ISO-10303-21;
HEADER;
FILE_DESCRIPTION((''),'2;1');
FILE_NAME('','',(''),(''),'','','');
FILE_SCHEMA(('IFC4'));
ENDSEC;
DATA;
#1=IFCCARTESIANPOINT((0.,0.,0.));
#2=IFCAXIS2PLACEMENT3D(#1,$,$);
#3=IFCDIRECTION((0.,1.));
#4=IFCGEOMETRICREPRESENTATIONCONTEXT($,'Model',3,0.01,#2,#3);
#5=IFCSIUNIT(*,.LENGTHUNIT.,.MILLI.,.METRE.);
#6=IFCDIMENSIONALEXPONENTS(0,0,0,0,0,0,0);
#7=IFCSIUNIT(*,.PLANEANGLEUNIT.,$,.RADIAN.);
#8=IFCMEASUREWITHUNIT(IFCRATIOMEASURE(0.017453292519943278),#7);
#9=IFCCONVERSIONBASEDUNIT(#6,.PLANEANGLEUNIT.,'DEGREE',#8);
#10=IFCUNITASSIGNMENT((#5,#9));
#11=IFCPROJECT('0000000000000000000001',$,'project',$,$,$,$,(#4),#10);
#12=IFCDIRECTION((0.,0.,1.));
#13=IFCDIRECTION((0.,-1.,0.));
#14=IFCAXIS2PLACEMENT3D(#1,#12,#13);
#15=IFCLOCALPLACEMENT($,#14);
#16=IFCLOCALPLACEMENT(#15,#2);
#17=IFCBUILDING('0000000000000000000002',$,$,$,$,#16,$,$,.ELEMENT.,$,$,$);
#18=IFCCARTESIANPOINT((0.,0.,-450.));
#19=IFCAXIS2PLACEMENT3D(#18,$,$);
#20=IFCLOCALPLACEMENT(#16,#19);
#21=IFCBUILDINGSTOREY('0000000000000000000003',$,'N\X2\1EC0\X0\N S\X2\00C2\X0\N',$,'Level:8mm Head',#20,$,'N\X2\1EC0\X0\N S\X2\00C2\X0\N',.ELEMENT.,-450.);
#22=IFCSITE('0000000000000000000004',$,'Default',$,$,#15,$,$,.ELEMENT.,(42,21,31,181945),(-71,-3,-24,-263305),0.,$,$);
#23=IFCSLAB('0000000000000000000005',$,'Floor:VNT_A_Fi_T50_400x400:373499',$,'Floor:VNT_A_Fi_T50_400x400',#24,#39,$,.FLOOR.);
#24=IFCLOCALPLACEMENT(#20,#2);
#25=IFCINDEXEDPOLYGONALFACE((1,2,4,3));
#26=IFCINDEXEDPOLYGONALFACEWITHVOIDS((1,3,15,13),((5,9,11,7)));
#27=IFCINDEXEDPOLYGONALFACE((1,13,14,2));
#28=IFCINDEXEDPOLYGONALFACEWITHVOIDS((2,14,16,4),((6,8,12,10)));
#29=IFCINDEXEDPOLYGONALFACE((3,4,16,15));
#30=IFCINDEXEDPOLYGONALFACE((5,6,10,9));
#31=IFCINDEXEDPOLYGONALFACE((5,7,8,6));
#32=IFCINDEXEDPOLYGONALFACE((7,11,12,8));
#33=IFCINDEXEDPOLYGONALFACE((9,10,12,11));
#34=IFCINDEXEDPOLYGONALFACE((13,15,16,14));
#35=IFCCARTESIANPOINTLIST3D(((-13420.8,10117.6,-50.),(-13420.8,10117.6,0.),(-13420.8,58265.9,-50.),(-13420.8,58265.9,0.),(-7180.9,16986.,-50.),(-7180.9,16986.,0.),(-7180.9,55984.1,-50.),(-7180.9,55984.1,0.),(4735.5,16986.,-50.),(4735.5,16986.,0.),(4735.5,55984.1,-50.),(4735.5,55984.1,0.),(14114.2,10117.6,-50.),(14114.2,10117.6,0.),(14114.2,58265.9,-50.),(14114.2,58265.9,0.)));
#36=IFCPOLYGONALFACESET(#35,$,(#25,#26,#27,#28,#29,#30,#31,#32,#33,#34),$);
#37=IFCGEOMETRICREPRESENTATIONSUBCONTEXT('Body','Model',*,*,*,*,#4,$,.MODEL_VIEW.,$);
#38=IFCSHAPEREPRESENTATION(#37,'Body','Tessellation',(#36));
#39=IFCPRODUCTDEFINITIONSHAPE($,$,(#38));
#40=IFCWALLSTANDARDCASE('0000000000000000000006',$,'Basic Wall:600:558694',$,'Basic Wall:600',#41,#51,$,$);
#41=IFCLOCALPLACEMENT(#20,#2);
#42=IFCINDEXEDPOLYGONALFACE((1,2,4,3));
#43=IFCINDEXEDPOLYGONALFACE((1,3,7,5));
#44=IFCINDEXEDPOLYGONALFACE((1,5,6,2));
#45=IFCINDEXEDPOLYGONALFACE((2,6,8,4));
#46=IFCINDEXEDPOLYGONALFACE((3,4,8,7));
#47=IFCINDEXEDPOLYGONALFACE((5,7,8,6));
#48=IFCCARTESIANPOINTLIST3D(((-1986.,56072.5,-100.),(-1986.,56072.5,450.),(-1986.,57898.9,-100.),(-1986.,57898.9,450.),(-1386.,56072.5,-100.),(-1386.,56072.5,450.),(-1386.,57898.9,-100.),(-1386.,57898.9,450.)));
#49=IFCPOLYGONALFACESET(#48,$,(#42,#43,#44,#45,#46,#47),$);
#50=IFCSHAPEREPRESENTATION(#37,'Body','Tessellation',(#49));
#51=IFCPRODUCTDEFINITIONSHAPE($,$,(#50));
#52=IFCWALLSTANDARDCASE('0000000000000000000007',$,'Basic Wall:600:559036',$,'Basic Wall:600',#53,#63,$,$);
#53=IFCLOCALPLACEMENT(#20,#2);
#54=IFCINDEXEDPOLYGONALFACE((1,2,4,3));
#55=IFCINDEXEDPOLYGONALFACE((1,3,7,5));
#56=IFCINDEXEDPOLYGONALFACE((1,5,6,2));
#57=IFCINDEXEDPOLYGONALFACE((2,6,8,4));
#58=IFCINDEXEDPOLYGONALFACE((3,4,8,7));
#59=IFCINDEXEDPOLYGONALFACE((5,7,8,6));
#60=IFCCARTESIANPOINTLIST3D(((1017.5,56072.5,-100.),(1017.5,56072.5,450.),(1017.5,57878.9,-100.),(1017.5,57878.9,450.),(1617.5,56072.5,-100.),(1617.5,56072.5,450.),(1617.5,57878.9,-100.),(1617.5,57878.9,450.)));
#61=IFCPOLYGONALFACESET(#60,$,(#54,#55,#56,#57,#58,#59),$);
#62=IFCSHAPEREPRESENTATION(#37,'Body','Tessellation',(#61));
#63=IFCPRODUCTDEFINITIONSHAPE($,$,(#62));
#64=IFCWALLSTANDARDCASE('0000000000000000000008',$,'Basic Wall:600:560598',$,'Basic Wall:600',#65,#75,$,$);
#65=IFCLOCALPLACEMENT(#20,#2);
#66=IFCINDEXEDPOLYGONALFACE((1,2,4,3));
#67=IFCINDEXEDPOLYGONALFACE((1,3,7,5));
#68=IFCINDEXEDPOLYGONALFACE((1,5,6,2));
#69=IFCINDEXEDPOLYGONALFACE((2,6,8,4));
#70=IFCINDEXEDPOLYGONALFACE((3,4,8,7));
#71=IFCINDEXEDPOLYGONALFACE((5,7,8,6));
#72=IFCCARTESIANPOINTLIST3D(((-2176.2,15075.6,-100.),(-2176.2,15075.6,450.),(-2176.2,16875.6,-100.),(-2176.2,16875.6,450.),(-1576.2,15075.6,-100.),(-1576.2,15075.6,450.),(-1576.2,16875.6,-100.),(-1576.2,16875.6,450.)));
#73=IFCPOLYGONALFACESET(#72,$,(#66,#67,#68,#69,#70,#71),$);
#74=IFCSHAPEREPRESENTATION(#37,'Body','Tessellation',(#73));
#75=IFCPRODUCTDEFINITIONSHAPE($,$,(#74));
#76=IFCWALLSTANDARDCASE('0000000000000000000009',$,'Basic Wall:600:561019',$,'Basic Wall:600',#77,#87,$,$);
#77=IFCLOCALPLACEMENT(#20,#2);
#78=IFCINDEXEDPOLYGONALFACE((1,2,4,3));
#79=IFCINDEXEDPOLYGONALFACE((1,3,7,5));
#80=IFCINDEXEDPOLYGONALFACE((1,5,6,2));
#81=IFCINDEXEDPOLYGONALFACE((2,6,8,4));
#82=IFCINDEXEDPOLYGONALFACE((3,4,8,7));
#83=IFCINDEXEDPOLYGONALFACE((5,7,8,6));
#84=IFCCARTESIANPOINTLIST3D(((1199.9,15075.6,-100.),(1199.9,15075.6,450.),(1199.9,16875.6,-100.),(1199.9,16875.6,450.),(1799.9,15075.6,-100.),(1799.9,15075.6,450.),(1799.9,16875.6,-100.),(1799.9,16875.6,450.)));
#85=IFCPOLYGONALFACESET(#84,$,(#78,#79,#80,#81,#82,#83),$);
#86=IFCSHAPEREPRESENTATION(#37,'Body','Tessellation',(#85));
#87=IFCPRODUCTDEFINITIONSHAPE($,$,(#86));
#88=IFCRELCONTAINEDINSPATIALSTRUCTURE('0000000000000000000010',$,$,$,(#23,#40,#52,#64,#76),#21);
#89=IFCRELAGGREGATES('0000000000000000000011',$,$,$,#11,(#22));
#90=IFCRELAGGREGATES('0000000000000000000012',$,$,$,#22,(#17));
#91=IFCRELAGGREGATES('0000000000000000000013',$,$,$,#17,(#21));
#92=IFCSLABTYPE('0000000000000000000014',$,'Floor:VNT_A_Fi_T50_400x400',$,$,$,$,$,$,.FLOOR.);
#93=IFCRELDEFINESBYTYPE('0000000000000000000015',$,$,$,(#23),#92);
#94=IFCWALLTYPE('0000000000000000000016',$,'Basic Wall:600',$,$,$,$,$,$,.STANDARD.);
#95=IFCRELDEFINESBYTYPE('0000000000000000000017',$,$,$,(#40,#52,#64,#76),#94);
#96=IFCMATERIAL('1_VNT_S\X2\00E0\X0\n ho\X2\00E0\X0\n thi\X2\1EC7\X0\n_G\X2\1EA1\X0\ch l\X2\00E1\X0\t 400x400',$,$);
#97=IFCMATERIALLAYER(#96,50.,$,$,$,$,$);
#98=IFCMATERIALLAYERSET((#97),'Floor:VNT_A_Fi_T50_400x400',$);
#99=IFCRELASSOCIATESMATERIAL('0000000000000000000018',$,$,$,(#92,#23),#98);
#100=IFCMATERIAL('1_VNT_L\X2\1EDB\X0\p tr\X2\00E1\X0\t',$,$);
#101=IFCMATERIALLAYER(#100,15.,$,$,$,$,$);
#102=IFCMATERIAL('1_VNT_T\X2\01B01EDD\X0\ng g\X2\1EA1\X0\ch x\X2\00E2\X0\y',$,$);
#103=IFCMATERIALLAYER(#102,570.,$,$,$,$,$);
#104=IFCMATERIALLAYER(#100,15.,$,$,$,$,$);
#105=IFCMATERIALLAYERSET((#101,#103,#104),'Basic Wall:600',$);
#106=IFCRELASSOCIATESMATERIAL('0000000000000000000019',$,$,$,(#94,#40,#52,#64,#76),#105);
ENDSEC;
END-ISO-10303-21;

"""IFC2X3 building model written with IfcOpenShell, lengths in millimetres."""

from ifc_helpers import new_model, entity, si_unit, converted_unit, direction, frame, frame_2d, origin, origin_2d_with_axis, place, context, subcontext, project, spatial, rectangle, extrude, material, layer, layer_set, layer_usage, type_object, element, save


model = new_model("IFC2X3")

# Units and contexts
model_context = context("Model", 3, precision=0.01, world=origin(), true_north=direction((0.0, 1.0)))
body_context = subcontext(model_context, "Body", "Model", "MODEL_VIEW")
ifc_project = project(units=[si_unit("LENGTHUNIT", "METRE", prefix="MILLI"), converted_unit("PLANEANGLEUNIT", "DEGREE", entity("IfcRatioMeasure", 0.017453292519943278), si_unit("PLANEANGLEUNIT", "RADIAN"), dimensions=[0, 0, 0, 0, 0, 0, 0])], contexts=[model_context])

# Site, building, storey
site_placement = place(None, frame((0.0, 0.0, 0.0), z_axis=(0.0, 0.0, 1.0), x_axis=(0.0, -1.0, 0.0)))
site = spatial("IfcSite", under=ifc_project, at=site_placement, Name="Default", CompositionType="ELEMENT", RefLatitude=(42, 21, 31, 181945), RefLongitude=(-71, -3, -24, -263305), RefElevation=0.0)
building_placement = place(site_placement, origin())
building = spatial("IfcBuilding", under=site, at=building_placement, CompositionType="ELEMENT")
storey_placement = place(building_placement, frame((0.0, 0.0, -450.0)))
storey = spatial("IfcBuildingStorey", under=building, at=storey_placement, Name="NỀN SÂN", ObjectType="Level:8mm Head", LongName="NỀN SÂN", CompositionType="ELEMENT", Elevation=-450.0)

# Slab, opening
ifc_material_1 = material(Name="1_VNT_Sàn hoàn thiện_Gạch lát 400x400")
ifc_layer_1 = layer(ifc_material_1, 50.0)
ifc_layer_set_1 = layer_set([ifc_layer_1], Name="Floor:VNT_A_Fi_T50_400x400")
ifc_layer_usage_1 = layer_usage(ifc_layer_set_1, "AXIS3", "POSITIVE", 0.0)
slab_type = type_object("IfcSlabType", Name="Floor:VNT_A_Fi_T50_400x400", PredefinedType="FLOOR", material=ifc_layer_set_1)
slab_placement = place(storey_placement, frame((-13420.8, 10117.6, -50.0)))
slab = element("IfcSlab", 1, at=slab_placement, inside=storey, type_object=slab_type, material=ifc_layer_usage_1, Name="Floor:VNT_A_Fi_T50_400x400:373499", ObjectType="Floor:VNT_A_Fi_T50_400x400", PredefinedType="FLOOR", context=body_context, shape_type="SweptSolid", body=[
    extrude(rectangle(XDim=48148.4, YDim=27535.0, at=frame_2d((0.0, 0.0), x_axis=(0.0, -1.0))), frame((13767.5, 24074.2, 50.0), z_axis=(0.0, 0.0, -1.0), x_axis=(-1.0, 0.0, 0.0)), (0.0, 0.0, 1.0), 50.0),
])
opening_placement = place(slab_placement, origin())
element("IfcOpeningElement", 2, at=opening_placement, cuts=slab, ObjectType="Opening", context=body_context, shape_type="SweptSolid", body=[
    extrude(rectangle(XDim=38998.0, YDim=11916.5, at=origin_2d_with_axis()), frame((12198.1, 26367.5, 50.0), z_axis=(0.0, 0.0, 1.0), x_axis=(0.0, -1.0, 0.0)), (0.0, 0.0, -1.0), 50.0),
])

# Walls
ifc_material_2 = material(Name="1_VNT_Lớp trát")
ifc_layer_2 = layer(ifc_material_2, 15.0)
ifc_material_3 = material(Name="1_VNT_Tường gạch xây")
ifc_layer_3 = layer(ifc_material_3, 570.0)
ifc_layer_4 = layer(ifc_material_2, 15.0)
ifc_layer_set_2 = layer_set([ifc_layer_2, ifc_layer_3, ifc_layer_4], Name="Basic Wall:600")
ifc_layer_usage_2 = layer_usage(ifc_layer_set_2, "AXIS2", "NEGATIVE", 300.0)
wall_type = type_object("IfcWallType", Name="Basic Wall:600", PredefinedType="STANDARD", material=ifc_layer_set_2)
wall_1_placement = place(storey_placement, frame((-1686.0, 57898.9, -100.0), z_axis=(0.0, 0.0, 1.0), x_axis=(0.0, -1.0, 0.0)))
element("IfcWallStandardCase", 3, at=wall_1_placement, inside=storey, type_object=wall_type, material=ifc_layer_usage_2, Name="Basic Wall:600:558694", ObjectType="Basic Wall:600", context=body_context, shape_type="SweptSolid", body=[
    extrude(rectangle(XDim=1826.4, YDim=600.0, at=frame_2d((913.2, 0.0), x_axis=(-1.0, 0.0))), origin(), (0.0, 0.0, 1.0), 550.0),
])
wall_2_placement = place(storey_placement, frame((1317.5, 57878.9, -100.0), z_axis=(0.0, 0.0, 1.0), x_axis=(0.0, -1.0, 0.0)))
element("IfcWallStandardCase", 4, at=wall_2_placement, inside=storey, type_object=wall_type, material=ifc_layer_usage_2, Name="Basic Wall:600:559036", ObjectType="Basic Wall:600", context=body_context, shape_type="SweptSolid", body=[
    extrude(rectangle(XDim=1806.4, YDim=600.0, at=frame_2d((903.2, 0.0), x_axis=(-1.0, 0.0))), origin(), (0.0, 0.0, 1.0), 550.0),
])
wall_3_placement = place(storey_placement, frame((-1876.2, 15075.6, -100.0), z_axis=(0.0, 0.0, 1.0), x_axis=(0.0, 1.0, 0.0)))
element("IfcWallStandardCase", 5, at=wall_3_placement, inside=storey, type_object=wall_type, material=ifc_layer_usage_2, Name="Basic Wall:600:560598", ObjectType="Basic Wall:600", context=body_context, shape_type="SweptSolid", body=[
    extrude(rectangle(XDim=1800.0, YDim=600.0, at=frame_2d((900.0, 0.0), x_axis=(-1.0, 0.0))), origin(), (0.0, 0.0, 1.0), 550.0),
])
wall_4_placement = place(storey_placement, frame((1499.9, 15075.6, -100.0), z_axis=(0.0, 0.0, 1.0), x_axis=(0.0, 1.0, 0.0)))
element("IfcWallStandardCase", 6, at=wall_4_placement, inside=storey, type_object=wall_type, material=ifc_layer_usage_2, Name="Basic Wall:600:561019", ObjectType="Basic Wall:600", context=body_context, shape_type="SweptSolid", body=[
    extrude(rectangle(XDim=1800.0, YDim=600.0, at=frame_2d((900.0, 0.0), x_axis=(-1.0, 0.0))), origin(), (0.0, 0.0, 1.0), 550.0),
])

save(model, "model.ifc")
